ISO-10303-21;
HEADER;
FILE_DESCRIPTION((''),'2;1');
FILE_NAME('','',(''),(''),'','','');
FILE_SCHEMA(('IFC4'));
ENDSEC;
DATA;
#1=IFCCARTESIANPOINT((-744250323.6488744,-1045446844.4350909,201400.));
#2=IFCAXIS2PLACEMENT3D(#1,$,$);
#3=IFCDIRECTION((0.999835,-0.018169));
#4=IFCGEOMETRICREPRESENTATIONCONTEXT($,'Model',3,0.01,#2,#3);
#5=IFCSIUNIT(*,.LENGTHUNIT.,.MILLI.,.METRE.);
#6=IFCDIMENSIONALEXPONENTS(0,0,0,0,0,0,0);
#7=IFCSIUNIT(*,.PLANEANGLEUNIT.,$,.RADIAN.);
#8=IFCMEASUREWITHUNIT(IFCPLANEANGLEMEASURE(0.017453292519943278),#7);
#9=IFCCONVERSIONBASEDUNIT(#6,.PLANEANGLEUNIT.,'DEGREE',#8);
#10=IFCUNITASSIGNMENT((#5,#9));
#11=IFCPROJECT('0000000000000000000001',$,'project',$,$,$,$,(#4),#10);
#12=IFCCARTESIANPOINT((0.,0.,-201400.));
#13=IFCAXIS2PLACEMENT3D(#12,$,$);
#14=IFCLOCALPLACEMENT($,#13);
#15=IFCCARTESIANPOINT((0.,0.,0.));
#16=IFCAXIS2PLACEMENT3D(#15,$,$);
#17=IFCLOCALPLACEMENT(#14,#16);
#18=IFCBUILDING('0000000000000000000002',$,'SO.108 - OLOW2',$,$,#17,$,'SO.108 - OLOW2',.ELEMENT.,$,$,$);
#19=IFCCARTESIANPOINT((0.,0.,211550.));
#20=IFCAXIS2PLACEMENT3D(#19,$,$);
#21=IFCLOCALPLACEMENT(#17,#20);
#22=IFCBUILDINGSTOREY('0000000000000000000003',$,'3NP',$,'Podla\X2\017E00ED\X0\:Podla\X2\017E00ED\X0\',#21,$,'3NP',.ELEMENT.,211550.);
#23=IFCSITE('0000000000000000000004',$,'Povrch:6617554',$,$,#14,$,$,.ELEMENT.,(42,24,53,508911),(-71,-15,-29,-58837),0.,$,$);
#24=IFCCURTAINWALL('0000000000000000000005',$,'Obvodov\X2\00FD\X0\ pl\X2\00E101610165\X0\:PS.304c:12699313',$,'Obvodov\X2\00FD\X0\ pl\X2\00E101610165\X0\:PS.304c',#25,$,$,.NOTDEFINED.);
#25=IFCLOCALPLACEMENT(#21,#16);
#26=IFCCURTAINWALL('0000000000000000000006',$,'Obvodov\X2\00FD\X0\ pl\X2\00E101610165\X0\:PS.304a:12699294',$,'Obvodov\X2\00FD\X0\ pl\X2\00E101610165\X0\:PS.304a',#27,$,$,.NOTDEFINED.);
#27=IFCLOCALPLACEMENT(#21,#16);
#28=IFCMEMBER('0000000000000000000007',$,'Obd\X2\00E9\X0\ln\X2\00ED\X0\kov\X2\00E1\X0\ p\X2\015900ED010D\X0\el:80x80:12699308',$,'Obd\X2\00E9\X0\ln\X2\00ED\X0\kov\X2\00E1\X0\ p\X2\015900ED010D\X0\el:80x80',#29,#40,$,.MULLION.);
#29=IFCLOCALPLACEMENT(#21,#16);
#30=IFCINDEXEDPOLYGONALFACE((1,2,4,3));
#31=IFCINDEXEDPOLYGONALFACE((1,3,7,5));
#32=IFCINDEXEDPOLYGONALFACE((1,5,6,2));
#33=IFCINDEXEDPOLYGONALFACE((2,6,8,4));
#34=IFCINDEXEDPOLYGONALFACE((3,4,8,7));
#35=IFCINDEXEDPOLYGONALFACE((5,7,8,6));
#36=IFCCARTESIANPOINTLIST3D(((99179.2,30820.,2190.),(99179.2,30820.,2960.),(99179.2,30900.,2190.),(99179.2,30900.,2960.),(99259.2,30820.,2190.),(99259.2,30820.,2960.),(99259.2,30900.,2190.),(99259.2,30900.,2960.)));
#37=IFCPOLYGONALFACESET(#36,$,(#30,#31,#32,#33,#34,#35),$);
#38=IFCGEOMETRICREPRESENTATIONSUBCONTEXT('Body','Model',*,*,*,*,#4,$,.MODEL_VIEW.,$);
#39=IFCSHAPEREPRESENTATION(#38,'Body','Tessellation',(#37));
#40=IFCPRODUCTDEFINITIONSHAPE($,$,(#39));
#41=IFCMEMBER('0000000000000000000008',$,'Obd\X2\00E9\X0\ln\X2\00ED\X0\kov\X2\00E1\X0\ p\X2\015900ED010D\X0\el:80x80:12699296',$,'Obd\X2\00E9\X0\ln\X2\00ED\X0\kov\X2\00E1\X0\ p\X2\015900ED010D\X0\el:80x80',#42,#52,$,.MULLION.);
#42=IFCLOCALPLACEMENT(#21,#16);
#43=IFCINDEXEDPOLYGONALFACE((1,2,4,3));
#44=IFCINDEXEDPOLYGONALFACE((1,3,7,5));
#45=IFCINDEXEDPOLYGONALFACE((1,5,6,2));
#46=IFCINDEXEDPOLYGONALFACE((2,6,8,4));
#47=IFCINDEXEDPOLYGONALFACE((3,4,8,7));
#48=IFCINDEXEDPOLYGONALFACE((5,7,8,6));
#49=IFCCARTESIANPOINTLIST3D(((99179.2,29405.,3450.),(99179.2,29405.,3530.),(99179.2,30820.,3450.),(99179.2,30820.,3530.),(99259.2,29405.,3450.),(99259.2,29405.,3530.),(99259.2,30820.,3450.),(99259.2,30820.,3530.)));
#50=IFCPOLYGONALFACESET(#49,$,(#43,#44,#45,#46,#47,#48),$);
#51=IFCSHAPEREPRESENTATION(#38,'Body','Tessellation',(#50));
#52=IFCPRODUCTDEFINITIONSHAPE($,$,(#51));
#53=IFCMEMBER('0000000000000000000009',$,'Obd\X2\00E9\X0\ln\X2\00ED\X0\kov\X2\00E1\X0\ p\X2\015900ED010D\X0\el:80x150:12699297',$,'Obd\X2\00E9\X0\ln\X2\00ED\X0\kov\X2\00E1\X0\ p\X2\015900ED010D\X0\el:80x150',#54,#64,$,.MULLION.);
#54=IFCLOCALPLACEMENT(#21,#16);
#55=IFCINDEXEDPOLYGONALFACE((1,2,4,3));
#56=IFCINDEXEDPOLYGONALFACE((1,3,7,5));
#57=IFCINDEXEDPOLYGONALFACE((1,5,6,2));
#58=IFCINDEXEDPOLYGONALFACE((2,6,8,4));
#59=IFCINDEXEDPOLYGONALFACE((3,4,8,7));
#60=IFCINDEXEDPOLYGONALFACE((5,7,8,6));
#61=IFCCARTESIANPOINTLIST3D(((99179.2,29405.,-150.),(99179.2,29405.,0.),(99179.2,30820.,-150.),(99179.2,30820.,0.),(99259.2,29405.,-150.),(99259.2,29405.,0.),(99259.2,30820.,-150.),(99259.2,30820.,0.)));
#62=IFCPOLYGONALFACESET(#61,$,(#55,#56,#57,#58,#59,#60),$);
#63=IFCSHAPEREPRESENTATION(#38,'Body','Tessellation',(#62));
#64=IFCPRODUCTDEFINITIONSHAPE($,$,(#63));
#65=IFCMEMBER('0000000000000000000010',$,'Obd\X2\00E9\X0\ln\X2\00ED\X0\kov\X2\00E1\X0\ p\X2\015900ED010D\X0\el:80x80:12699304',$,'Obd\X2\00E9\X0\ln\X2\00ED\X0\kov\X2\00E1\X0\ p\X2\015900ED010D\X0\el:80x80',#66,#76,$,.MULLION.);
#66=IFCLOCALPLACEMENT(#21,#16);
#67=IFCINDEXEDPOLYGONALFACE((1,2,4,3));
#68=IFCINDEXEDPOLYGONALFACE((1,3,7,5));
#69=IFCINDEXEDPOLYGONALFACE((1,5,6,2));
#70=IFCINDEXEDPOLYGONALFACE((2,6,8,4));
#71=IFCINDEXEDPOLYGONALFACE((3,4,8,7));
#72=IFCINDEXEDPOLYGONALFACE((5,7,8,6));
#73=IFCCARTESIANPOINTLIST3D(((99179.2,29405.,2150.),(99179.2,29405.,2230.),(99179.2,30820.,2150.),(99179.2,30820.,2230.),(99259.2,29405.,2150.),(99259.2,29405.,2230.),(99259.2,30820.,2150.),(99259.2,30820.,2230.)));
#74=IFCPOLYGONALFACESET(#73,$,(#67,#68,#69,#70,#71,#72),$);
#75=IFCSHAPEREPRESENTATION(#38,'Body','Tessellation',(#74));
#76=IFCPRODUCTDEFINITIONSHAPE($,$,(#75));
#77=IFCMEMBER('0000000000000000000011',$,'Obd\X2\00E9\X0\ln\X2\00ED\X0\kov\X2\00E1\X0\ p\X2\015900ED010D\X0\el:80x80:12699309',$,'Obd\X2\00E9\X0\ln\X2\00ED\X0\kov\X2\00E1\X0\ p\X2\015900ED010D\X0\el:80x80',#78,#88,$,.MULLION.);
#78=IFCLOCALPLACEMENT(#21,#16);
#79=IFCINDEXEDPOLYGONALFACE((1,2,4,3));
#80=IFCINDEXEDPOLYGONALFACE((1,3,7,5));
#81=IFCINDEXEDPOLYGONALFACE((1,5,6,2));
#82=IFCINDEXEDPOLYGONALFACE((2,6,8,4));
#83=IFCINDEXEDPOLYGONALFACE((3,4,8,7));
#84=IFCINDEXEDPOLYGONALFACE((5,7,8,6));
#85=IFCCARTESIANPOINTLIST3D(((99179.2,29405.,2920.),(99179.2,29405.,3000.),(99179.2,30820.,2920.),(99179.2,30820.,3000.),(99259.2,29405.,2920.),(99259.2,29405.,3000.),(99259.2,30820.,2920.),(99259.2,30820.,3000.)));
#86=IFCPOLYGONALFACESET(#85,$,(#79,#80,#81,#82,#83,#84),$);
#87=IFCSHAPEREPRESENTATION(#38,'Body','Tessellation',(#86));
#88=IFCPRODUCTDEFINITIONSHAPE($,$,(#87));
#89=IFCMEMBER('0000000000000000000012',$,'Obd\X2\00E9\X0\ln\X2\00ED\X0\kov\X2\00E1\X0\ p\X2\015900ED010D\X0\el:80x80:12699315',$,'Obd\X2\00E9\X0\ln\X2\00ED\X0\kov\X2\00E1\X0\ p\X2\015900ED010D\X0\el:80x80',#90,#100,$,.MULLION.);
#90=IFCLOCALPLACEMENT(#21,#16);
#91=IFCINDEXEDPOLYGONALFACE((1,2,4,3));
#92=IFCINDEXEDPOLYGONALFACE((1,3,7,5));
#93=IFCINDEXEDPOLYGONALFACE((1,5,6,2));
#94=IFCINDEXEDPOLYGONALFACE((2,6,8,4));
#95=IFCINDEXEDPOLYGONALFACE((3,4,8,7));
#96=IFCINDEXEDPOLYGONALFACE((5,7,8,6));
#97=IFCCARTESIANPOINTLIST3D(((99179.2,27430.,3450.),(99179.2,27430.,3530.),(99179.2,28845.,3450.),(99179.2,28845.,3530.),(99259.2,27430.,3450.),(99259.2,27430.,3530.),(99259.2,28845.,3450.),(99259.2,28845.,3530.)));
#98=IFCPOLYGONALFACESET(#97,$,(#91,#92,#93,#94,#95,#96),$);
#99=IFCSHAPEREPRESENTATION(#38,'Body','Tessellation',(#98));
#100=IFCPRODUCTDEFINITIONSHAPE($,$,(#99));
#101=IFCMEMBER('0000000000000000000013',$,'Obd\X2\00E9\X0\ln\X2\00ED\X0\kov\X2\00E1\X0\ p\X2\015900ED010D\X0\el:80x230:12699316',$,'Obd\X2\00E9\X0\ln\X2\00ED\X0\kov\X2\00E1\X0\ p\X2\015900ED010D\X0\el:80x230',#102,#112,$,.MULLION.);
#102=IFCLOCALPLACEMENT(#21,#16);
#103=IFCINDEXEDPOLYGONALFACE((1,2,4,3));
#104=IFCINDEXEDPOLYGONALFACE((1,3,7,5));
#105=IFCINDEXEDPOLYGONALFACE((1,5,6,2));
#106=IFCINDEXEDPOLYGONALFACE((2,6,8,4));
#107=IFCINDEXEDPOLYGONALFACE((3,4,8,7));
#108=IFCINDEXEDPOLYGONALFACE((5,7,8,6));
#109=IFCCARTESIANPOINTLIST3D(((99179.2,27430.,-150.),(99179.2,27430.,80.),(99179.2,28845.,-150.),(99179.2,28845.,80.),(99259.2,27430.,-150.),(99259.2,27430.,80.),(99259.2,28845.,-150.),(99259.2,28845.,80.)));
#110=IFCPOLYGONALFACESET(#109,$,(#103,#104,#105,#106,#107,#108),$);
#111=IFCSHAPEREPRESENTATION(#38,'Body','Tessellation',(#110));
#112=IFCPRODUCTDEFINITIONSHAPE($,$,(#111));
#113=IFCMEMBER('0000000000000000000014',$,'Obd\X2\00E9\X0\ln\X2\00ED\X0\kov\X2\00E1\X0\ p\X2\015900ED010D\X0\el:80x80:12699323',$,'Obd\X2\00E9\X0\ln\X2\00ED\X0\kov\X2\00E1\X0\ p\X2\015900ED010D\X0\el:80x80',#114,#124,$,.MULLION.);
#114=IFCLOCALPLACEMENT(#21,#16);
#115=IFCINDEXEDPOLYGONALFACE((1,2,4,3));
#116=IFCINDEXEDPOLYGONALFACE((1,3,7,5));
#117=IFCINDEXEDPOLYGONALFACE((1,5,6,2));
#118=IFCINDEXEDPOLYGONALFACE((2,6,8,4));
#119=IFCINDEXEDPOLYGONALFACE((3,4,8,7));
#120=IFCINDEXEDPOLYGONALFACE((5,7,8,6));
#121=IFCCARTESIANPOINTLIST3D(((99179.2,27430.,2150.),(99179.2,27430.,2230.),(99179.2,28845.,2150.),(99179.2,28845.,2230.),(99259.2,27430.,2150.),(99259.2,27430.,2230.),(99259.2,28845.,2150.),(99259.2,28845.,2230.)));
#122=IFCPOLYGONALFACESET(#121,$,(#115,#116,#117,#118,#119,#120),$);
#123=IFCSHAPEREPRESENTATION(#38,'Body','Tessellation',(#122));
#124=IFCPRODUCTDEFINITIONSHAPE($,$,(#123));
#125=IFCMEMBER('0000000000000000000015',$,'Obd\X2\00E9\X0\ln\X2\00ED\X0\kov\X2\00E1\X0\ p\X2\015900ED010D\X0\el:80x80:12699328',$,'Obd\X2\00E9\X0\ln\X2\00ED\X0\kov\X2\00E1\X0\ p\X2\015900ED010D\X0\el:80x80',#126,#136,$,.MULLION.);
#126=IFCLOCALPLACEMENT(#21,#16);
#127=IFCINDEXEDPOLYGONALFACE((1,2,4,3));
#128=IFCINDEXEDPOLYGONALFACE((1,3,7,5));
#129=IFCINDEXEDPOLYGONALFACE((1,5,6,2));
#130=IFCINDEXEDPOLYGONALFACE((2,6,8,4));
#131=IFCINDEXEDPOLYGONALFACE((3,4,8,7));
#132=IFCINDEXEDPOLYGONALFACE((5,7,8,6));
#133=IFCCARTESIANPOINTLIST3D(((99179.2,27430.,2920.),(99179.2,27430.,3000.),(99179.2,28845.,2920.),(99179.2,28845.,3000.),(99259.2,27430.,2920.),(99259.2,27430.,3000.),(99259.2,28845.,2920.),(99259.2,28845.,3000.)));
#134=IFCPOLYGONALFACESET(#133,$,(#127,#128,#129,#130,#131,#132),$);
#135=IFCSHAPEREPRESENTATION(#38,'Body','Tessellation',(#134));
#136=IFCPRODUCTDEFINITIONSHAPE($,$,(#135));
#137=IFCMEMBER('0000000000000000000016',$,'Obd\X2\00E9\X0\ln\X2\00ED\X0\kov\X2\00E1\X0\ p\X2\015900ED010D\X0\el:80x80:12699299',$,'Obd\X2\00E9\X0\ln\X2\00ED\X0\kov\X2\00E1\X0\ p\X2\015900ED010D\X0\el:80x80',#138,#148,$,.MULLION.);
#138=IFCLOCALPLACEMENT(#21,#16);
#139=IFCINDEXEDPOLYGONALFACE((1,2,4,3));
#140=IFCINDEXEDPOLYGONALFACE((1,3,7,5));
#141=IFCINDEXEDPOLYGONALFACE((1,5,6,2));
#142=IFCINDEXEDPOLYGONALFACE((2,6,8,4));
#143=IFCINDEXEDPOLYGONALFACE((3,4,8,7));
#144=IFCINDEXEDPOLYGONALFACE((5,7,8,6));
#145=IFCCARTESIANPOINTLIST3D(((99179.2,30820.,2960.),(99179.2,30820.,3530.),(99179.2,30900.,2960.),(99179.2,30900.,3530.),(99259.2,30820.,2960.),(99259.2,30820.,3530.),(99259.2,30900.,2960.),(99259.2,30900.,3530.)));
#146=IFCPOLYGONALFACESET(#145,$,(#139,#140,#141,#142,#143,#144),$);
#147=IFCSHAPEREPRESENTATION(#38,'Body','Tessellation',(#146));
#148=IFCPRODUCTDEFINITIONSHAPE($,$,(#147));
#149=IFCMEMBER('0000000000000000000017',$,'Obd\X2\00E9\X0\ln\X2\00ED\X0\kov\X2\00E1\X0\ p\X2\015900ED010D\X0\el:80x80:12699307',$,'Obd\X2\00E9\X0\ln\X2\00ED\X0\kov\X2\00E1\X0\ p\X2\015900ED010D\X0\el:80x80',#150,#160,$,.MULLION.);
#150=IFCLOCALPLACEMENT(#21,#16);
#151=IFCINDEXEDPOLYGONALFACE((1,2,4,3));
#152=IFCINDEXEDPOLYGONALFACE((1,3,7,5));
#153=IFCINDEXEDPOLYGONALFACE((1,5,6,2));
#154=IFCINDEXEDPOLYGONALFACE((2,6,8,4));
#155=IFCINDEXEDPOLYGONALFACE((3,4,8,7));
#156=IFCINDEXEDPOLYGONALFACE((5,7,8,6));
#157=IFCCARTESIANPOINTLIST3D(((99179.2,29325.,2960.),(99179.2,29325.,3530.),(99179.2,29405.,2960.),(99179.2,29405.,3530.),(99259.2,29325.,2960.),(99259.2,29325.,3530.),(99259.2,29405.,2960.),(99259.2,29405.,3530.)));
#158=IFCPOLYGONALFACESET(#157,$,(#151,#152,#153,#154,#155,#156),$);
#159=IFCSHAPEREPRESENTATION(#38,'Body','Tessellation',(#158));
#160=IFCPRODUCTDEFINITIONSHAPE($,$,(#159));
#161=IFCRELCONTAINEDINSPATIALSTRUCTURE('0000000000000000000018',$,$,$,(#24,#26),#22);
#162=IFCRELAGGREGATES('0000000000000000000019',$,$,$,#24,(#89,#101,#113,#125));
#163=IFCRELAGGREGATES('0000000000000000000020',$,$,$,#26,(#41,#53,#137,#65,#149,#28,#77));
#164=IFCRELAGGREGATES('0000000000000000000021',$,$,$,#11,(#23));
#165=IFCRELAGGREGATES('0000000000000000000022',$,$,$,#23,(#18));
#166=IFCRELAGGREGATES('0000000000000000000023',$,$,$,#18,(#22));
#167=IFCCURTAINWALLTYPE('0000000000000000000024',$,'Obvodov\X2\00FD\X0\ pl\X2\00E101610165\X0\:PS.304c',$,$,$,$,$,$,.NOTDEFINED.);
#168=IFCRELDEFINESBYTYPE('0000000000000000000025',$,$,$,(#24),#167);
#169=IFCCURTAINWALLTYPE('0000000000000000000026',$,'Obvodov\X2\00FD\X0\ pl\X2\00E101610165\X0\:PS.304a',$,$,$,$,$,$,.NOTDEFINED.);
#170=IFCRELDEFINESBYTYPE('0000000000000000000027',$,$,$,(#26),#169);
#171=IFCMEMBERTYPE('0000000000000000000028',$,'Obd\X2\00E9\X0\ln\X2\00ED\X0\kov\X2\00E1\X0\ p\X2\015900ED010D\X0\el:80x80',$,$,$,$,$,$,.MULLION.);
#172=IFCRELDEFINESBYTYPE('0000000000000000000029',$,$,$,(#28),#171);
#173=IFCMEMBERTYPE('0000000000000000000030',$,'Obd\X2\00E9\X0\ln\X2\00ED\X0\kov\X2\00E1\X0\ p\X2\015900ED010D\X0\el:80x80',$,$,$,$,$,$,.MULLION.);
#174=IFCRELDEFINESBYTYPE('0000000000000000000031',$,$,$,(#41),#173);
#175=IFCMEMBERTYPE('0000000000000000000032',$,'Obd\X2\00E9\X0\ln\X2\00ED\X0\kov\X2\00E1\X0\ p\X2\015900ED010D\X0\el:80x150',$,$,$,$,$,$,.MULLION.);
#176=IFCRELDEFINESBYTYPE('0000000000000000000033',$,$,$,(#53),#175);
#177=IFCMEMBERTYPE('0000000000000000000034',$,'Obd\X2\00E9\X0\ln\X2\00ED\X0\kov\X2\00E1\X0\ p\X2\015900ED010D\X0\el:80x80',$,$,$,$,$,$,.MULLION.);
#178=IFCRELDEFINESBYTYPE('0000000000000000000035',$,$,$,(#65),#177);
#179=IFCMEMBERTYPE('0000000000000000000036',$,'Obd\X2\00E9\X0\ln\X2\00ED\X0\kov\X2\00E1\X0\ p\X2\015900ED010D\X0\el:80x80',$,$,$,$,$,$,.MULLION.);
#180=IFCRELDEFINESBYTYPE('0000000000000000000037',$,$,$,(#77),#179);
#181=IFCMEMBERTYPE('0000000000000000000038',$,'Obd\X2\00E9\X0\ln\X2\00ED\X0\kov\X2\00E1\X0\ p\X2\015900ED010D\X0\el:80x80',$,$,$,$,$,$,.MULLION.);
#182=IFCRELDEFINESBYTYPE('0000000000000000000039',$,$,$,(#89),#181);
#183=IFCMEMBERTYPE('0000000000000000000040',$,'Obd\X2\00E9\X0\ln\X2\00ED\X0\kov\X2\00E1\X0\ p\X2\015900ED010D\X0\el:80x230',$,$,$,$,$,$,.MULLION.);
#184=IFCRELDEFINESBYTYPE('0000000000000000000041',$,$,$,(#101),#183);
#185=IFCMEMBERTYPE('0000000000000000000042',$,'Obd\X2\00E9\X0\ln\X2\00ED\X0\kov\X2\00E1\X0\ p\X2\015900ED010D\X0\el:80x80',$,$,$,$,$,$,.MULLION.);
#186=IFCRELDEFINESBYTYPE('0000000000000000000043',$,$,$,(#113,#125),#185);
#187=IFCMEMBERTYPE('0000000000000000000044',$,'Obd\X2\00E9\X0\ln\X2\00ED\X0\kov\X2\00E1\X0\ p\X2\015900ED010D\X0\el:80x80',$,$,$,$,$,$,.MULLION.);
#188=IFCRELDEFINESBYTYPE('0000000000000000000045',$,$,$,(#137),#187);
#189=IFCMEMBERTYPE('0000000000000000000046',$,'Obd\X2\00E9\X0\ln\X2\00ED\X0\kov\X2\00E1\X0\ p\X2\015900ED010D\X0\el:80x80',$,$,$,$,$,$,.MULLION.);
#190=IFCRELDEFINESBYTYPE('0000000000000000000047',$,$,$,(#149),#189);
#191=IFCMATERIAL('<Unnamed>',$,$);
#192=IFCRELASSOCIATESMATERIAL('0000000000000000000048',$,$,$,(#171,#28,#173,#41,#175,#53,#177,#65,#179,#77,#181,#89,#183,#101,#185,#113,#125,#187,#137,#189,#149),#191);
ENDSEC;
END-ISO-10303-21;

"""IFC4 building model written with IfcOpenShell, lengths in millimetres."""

from ifc_helpers import new_model, entity, si_unit, converted_unit, direction, frame, origin, place, context, subcontext, project, spatial, indexed_curve, outline, extrude, source, transform, mapped, material, type_object, type_shapes, element, aggregate, save


model = new_model("IFC4")

# Units and contexts
model_context = context("Model", 3, precision=0.01, world=frame((-744250323.6488744, -1045446844.4350909, 201400.0)), true_north=direction((0.999835, -0.018169)))
body_context = subcontext(model_context, "Body", "Model", "MODEL_VIEW")
ifc_project = project(units=[si_unit("LENGTHUNIT", "METRE", prefix="MILLI"), converted_unit("PLANEANGLEUNIT", "DEGREE", entity("IfcPlaneAngleMeasure", 0.017453292519943278), si_unit("PLANEANGLEUNIT", "RADIAN"), dimensions=[0, 0, 0, 0, 0, 0, 0])], contexts=[model_context])

# Site, building, storey
site_placement = place(None, frame((0.0, 0.0, -201400.0)))
site = spatial("IfcSite", under=ifc_project, at=site_placement, Name="Povrch:6617554", CompositionType="ELEMENT", RefLatitude=(42, 24, 53, 508911), RefLongitude=(-71, -15, -29, -58837), RefElevation=0.0)
building_placement = place(site_placement, origin())
building = spatial("IfcBuilding", under=site, at=building_placement, Name="SO.108 - OLOW2", LongName="SO.108 - OLOW2", CompositionType="ELEMENT")
storey_placement = place(building_placement, frame((0.0, 0.0, 211550.0)))
storey = spatial("IfcBuildingStorey", under=building, at=storey_placement, Name="3NP", ObjectType="Podlaží:Podlaží", LongName="3NP", CompositionType="ELEMENT", Elevation=211550.0)

# Curtain walls, members
ifc_material_1 = material(Name="<Unnamed>")
curtain_wall_type_1 = type_object("IfcCurtainWallType", Name="Obvodový plášť:PS.304c", PredefinedType="NOTDEFINED")
curtain_wall_1_placement = place(storey_placement, frame((0.0, 0.0, -211550.0)))
curtain_wall_1 = element("IfcCurtainWall", 1, at=curtain_wall_1_placement, inside=storey, type_object=curtain_wall_type_1, Name="Obvodový plášť:PS.304c:12699313", ObjectType="Obvodový plášť:PS.304c", PredefinedType="NOTDEFINED")
curtain_wall_type_2 = type_object("IfcCurtainWallType", Name="Obvodový plášť:PS.304a", PredefinedType="NOTDEFINED")
curtain_wall_2_placement = place(storey_placement, frame((0.0, 0.0, -211550.0)))
curtain_wall_2 = element("IfcCurtainWall", 2, at=curtain_wall_2_placement, inside=storey, type_object=curtain_wall_type_2, Name="Obvodový plášť:PS.304a:12699294", ObjectType="Obvodový plášť:PS.304a", PredefinedType="NOTDEFINED")
member_type_1 = type_object("IfcMemberType", Name="Obdélníková příčel:80x80", PredefinedType="MULLION", material=ifc_material_1)
shared_shape_1 = source(origin(), body_context, "Body", "SweptSolid", [
    extrude(outline(indexed_curve([(-40.0, -40.0), (40.0, -40.0), (40.0, 40.0), (-40.0, 40.0), (-40.0, -40.0)], self_intersect=False)), frame((-40.0, 0.0, -770.0), z_axis=(0.0, 0.0, 1.0), x_axis=(-1.0, 0.0, 0.0)), (0.0, 0.0, 1.0), 770.0),
])
type_shapes(member_type_1, [shared_shape_1])
member_1_placement = place(curtain_wall_2_placement, frame((99219.2, 30900.0, 214510.0), z_axis=(0.0, 0.0, 1.0), x_axis=(0.0, 1.0, 0.0)))
member_1 = element("IfcMember", 3, at=member_1_placement, type_object=member_type_1, material=ifc_material_1, Name="Obdélníková příčel:80x80:12699308", ObjectType="Obdélníková příčel:80x80", PredefinedType="MULLION", context=body_context, shape_type="MappedRepresentation", body=[
    mapped(shared_shape_1, transform((0.0, 0.0, 0.0), scale=1.0)),
])
member_type_2 = type_object("IfcMemberType", Name="Obdélníková příčel:80x80", PredefinedType="MULLION", material=ifc_material_1)
shared_shape_2 = source(origin(), body_context, "Body", "SweptSolid", [
    extrude(outline(indexed_curve([(-40.0, -40.0), (40.0, -40.0), (40.0, 40.0), (-40.0, 40.0), (-40.0, -40.0)], self_intersect=False)), frame((-40.0, 0.0, -1415.0), z_axis=(0.0, 0.0, 1.0), x_axis=(-1.0, 0.0, 0.0)), (0.0, 0.0, 1.0), 1415.0),
])
type_shapes(member_type_2, [shared_shape_2])
member_2_placement = place(curtain_wall_2_placement, frame((99219.2, 29405.0, 215080.0), z_axis=(0.0, -1.0, 0.0), x_axis=(0.0, 0.0, 1.0)))
member_2 = element("IfcMember", 4, at=member_2_placement, type_object=member_type_2, material=ifc_material_1, Name="Obdélníková příčel:80x80:12699296", ObjectType="Obdélníková příčel:80x80", PredefinedType="MULLION", context=body_context, shape_type="MappedRepresentation", body=[
    mapped(shared_shape_2, transform((0.0, 0.0, 0.0), scale=1.0)),
])
member_type_3 = type_object("IfcMemberType", Name="Obdélníková příčel:80x150", PredefinedType="MULLION", material=ifc_material_1)
shared_shape_3 = source(origin(), body_context, "Body", "SweptSolid", [
    extrude(outline(indexed_curve([(-75.0, -40.0), (75.0, -40.0), (75.0, 40.0), (-75.0, 40.0), (-75.0, -40.0)], self_intersect=False)), frame((-75.0, 0.0, -1415.0), z_axis=(0.0, 0.0, 1.0), x_axis=(-1.0, 0.0, 0.0)), (0.0, 0.0, 1.0), 1415.0),
])
type_shapes(member_type_3, [shared_shape_3])
member_3_placement = place(curtain_wall_2_placement, frame((99219.2, 30820.0, 211400.0), z_axis=(0.0, 1.0, 0.0), x_axis=(0.0, 0.0, -1.0)))
member_3 = element("IfcMember", 5, at=member_3_placement, type_object=member_type_3, material=ifc_material_1, Name="Obdélníková příčel:80x150:12699297", ObjectType="Obdélníková příčel:80x150", PredefinedType="MULLION", context=body_context, shape_type="MappedRepresentation", body=[
    mapped(shared_shape_3, transform((0.0, 0.0, 0.0), scale=1.0)),
])
member_type_4 = type_object("IfcMemberType", Name="Obdélníková příčel:80x80", PredefinedType="MULLION", material=ifc_material_1)
shared_shape_4 = source(origin(), body_context, "Body", "SweptSolid", [
    extrude(outline(indexed_curve([(-40.0, -40.0), (40.0, -40.0), (40.0, 40.0), (-40.0, 40.0), (-40.0, -40.0)], self_intersect=False)), frame((0.0, 0.0, -1415.0), z_axis=(0.0, 0.0, 1.0), x_axis=(-1.0, 0.0, 0.0)), (0.0, 0.0, 1.0), 1415.0),
])
type_shapes(member_type_4, [shared_shape_4])
member_4_placement = place(curtain_wall_2_placement, frame((99219.2, 29405.0, 213740.0), z_axis=(0.0, -1.0, 0.0), x_axis=(0.0, 0.0, 1.0)))
member_4 = element("IfcMember", 6, at=member_4_placement, type_object=member_type_4, material=ifc_material_1, Name="Obdélníková příčel:80x80:12699304", ObjectType="Obdélníková příčel:80x80", PredefinedType="MULLION", context=body_context, shape_type="MappedRepresentation", body=[
    mapped(shared_shape_4, transform((0.0, 0.0, 0.0), scale=1.0)),
])
member_type_5 = type_object("IfcMemberType", Name="Obdélníková příčel:80x80", PredefinedType="MULLION", material=ifc_material_1)
shared_shape_5 = source(origin(), body_context, "Body", "SweptSolid", [
    extrude(outline(indexed_curve([(-40.0, -40.0), (40.0, -40.0), (40.0, 40.0), (-40.0, 40.0), (-40.0, -40.0)], self_intersect=False)), frame((0.0, 0.0, -1415.0), z_axis=(0.0, 0.0, 1.0), x_axis=(-1.0, 0.0, 0.0)), (0.0, 0.0, 1.0), 1415.0),
])
type_shapes(member_type_5, [shared_shape_5])
member_5_placement = place(curtain_wall_2_placement, frame((99219.2, 29405.0, 214510.0), z_axis=(0.0, -1.0, 0.0), x_axis=(0.0, 0.0, 1.0)))
member_5 = element("IfcMember", 7, at=member_5_placement, type_object=member_type_5, material=ifc_material_1, Name="Obdélníková příčel:80x80:12699309", ObjectType="Obdélníková příčel:80x80", PredefinedType="MULLION", context=body_context, shape_type="MappedRepresentation", body=[
    mapped(shared_shape_5, transform((0.0, 0.0, 0.0), scale=1.0)),
])

# Members
member_type_6 = type_object("IfcMemberType", Name="Obdélníková příčel:80x80", PredefinedType="MULLION", material=ifc_material_1)
shared_shape_6 = source(origin(), body_context, "Body", "SweptSolid", [
    extrude(outline(indexed_curve([(-40.0, -40.0), (40.0, -40.0), (40.0, 40.0), (-40.0, 40.0), (-40.0, -40.0)], self_intersect=False)), frame((-40.0, 0.0, -1415.0), z_axis=(0.0, 0.0, 1.0), x_axis=(-1.0, 0.0, 0.0)), (0.0, 0.0, 1.0), 1415.0),
])
type_shapes(member_type_6, [shared_shape_6])
member_6_placement = place(curtain_wall_1_placement, frame((99219.2, 27430.0, 215080.0), z_axis=(0.0, -1.0, 0.0), x_axis=(0.0, 0.0, 1.0)))
member_6 = element("IfcMember", 8, at=member_6_placement, type_object=member_type_6, material=ifc_material_1, Name="Obdélníková příčel:80x80:12699315", ObjectType="Obdélníková příčel:80x80", PredefinedType="MULLION", context=body_context, shape_type="MappedRepresentation", body=[
    mapped(shared_shape_6, transform((0.0, 0.0, 0.0), scale=1.0)),
])
member_type_7 = type_object("IfcMemberType", Name="Obdélníková příčel:80x230", PredefinedType="MULLION", material=ifc_material_1)
shared_shape_7 = source(origin(), body_context, "Body", "SweptSolid", [
    extrude(outline(indexed_curve([(-115.0, -40.0), (115.0, -40.0), (115.0, 40.0), (-115.0, 40.0), (-115.0, -40.0)], self_intersect=False)), frame((-115.0, 0.0, -1415.0), z_axis=(0.0, 0.0, 1.0), x_axis=(-1.0, 0.0, 0.0)), (0.0, 0.0, 1.0), 1415.0),
])
type_shapes(member_type_7, [shared_shape_7])
member_7_placement = place(curtain_wall_1_placement, frame((99219.2, 28845.0, 211400.0), z_axis=(0.0, 1.0, 0.0), x_axis=(0.0, 0.0, -1.0)))
member_7 = element("IfcMember", 9, at=member_7_placement, type_object=member_type_7, material=ifc_material_1, Name="Obdélníková příčel:80x230:12699316", ObjectType="Obdélníková příčel:80x230", PredefinedType="MULLION", context=body_context, shape_type="MappedRepresentation", body=[
    mapped(shared_shape_7, transform((0.0, 0.0, 0.0), scale=1.0)),
])
member_type_8 = type_object("IfcMemberType", Name="Obdélníková příčel:80x80", PredefinedType="MULLION", material=ifc_material_1)
shared_shape_8 = source(origin(), body_context, "Body", "SweptSolid", [
    extrude(outline(indexed_curve([(-40.0, -40.0), (40.0, -40.0), (40.0, 40.0), (-40.0, 40.0), (-40.0, -40.0)], self_intersect=False)), frame((0.0, 0.0, -1415.0), z_axis=(0.0, 0.0, 1.0), x_axis=(-1.0, 0.0, 0.0)), (0.0, 0.0, 1.0), 1415.0),
])
type_shapes(member_type_8, [shared_shape_8])
member_8_placement = place(curtain_wall_1_placement, frame((99219.2, 27430.0, 213740.0), z_axis=(0.0, -1.0, 0.0), x_axis=(0.0, 0.0, 1.0)))
member_8 = element("IfcMember", 10, at=member_8_placement, type_object=member_type_8, material=ifc_material_1, Name="Obdélníková příčel:80x80:12699323", ObjectType="Obdélníková příčel:80x80", PredefinedType="MULLION", context=body_context, shape_type="MappedRepresentation", body=[
    mapped(shared_shape_8, transform((0.0, 0.0, 0.0), scale=1.0)),
])
member_9_placement = place(curtain_wall_1_placement, frame((99219.2, 27430.0, 214510.0), z_axis=(0.0, -1.0, 0.0), x_axis=(0.0, 0.0, 1.0)))
member_9 = element("IfcMember", 11, at=member_9_placement, type_object=member_type_8, material=ifc_material_1, Name="Obdélníková příčel:80x80:12699328", ObjectType="Obdélníková příčel:80x80", PredefinedType="MULLION", context=body_context, shape_type="MappedRepresentation", body=[
    mapped(shared_shape_8, transform((0.0, 0.0, 0.0), scale=1.0)),
])
member_type_9 = type_object("IfcMemberType", Name="Obdélníková příčel:80x80", PredefinedType="MULLION", material=ifc_material_1)
shared_shape_9 = source(origin(), body_context, "Body", "SweptSolid", [
    extrude(outline(indexed_curve([(-40.0, -40.0), (40.0, -40.0), (40.0, 40.0), (-40.0, 40.0), (-40.0, -40.0)], self_intersect=False)), frame((-40.0, 0.0, -570.0), z_axis=(0.0, 0.0, 1.0), x_axis=(-1.0, 0.0, 0.0)), (0.0, 0.0, 1.0), 570.0),
])
type_shapes(member_type_9, [shared_shape_9])
member_10_placement = place(curtain_wall_2_placement, frame((99219.2, 30900.0, 215080.0), z_axis=(0.0, 0.0, 1.0), x_axis=(0.0, 1.0, 0.0)))
member_10 = element("IfcMember", 12, at=member_10_placement, type_object=member_type_9, material=ifc_material_1, Name="Obdélníková příčel:80x80:12699299", ObjectType="Obdélníková příčel:80x80", PredefinedType="MULLION", context=body_context, shape_type="MappedRepresentation", body=[
    mapped(shared_shape_9, transform((0.0, 0.0, 0.0), scale=1.0)),
])
member_type_10 = type_object("IfcMemberType", Name="Obdélníková příčel:80x80", PredefinedType="MULLION", material=ifc_material_1)
shared_shape_10 = source(origin(), body_context, "Body", "SweptSolid", [
    extrude(outline(indexed_curve([(-40.0, -40.0), (40.0, -40.0), (40.0, 40.0), (-40.0, 40.0), (-40.0, -40.0)], self_intersect=False)), frame((-40.0, 0.0, -570.0), z_axis=(0.0, 0.0, 1.0), x_axis=(-1.0, 0.0, 0.0)), (0.0, 0.0, 1.0), 570.0),
])
type_shapes(member_type_10, [shared_shape_10])
member_11_placement = place(curtain_wall_2_placement, frame((99219.2, 29325.0, 214510.0), z_axis=(0.0, 0.0, -1.0), x_axis=(0.0, -1.0, 0.0)))
member_11 = element("IfcMember", 13, at=member_11_placement, type_object=member_type_10, material=ifc_material_1, Name="Obdélníková příčel:80x80:12699307", ObjectType="Obdélníková příčel:80x80", PredefinedType="MULLION", context=body_context, shape_type="MappedRepresentation", body=[
    mapped(shared_shape_10, transform((0.0, 0.0, 0.0), scale=1.0)),
])

aggregate(curtain_wall_1, [member_6, member_7, member_8, member_9])

aggregate(curtain_wall_2, [member_2, member_3, member_10, member_4, member_11, member_1, member_5])

save(model, "model.ifc")
